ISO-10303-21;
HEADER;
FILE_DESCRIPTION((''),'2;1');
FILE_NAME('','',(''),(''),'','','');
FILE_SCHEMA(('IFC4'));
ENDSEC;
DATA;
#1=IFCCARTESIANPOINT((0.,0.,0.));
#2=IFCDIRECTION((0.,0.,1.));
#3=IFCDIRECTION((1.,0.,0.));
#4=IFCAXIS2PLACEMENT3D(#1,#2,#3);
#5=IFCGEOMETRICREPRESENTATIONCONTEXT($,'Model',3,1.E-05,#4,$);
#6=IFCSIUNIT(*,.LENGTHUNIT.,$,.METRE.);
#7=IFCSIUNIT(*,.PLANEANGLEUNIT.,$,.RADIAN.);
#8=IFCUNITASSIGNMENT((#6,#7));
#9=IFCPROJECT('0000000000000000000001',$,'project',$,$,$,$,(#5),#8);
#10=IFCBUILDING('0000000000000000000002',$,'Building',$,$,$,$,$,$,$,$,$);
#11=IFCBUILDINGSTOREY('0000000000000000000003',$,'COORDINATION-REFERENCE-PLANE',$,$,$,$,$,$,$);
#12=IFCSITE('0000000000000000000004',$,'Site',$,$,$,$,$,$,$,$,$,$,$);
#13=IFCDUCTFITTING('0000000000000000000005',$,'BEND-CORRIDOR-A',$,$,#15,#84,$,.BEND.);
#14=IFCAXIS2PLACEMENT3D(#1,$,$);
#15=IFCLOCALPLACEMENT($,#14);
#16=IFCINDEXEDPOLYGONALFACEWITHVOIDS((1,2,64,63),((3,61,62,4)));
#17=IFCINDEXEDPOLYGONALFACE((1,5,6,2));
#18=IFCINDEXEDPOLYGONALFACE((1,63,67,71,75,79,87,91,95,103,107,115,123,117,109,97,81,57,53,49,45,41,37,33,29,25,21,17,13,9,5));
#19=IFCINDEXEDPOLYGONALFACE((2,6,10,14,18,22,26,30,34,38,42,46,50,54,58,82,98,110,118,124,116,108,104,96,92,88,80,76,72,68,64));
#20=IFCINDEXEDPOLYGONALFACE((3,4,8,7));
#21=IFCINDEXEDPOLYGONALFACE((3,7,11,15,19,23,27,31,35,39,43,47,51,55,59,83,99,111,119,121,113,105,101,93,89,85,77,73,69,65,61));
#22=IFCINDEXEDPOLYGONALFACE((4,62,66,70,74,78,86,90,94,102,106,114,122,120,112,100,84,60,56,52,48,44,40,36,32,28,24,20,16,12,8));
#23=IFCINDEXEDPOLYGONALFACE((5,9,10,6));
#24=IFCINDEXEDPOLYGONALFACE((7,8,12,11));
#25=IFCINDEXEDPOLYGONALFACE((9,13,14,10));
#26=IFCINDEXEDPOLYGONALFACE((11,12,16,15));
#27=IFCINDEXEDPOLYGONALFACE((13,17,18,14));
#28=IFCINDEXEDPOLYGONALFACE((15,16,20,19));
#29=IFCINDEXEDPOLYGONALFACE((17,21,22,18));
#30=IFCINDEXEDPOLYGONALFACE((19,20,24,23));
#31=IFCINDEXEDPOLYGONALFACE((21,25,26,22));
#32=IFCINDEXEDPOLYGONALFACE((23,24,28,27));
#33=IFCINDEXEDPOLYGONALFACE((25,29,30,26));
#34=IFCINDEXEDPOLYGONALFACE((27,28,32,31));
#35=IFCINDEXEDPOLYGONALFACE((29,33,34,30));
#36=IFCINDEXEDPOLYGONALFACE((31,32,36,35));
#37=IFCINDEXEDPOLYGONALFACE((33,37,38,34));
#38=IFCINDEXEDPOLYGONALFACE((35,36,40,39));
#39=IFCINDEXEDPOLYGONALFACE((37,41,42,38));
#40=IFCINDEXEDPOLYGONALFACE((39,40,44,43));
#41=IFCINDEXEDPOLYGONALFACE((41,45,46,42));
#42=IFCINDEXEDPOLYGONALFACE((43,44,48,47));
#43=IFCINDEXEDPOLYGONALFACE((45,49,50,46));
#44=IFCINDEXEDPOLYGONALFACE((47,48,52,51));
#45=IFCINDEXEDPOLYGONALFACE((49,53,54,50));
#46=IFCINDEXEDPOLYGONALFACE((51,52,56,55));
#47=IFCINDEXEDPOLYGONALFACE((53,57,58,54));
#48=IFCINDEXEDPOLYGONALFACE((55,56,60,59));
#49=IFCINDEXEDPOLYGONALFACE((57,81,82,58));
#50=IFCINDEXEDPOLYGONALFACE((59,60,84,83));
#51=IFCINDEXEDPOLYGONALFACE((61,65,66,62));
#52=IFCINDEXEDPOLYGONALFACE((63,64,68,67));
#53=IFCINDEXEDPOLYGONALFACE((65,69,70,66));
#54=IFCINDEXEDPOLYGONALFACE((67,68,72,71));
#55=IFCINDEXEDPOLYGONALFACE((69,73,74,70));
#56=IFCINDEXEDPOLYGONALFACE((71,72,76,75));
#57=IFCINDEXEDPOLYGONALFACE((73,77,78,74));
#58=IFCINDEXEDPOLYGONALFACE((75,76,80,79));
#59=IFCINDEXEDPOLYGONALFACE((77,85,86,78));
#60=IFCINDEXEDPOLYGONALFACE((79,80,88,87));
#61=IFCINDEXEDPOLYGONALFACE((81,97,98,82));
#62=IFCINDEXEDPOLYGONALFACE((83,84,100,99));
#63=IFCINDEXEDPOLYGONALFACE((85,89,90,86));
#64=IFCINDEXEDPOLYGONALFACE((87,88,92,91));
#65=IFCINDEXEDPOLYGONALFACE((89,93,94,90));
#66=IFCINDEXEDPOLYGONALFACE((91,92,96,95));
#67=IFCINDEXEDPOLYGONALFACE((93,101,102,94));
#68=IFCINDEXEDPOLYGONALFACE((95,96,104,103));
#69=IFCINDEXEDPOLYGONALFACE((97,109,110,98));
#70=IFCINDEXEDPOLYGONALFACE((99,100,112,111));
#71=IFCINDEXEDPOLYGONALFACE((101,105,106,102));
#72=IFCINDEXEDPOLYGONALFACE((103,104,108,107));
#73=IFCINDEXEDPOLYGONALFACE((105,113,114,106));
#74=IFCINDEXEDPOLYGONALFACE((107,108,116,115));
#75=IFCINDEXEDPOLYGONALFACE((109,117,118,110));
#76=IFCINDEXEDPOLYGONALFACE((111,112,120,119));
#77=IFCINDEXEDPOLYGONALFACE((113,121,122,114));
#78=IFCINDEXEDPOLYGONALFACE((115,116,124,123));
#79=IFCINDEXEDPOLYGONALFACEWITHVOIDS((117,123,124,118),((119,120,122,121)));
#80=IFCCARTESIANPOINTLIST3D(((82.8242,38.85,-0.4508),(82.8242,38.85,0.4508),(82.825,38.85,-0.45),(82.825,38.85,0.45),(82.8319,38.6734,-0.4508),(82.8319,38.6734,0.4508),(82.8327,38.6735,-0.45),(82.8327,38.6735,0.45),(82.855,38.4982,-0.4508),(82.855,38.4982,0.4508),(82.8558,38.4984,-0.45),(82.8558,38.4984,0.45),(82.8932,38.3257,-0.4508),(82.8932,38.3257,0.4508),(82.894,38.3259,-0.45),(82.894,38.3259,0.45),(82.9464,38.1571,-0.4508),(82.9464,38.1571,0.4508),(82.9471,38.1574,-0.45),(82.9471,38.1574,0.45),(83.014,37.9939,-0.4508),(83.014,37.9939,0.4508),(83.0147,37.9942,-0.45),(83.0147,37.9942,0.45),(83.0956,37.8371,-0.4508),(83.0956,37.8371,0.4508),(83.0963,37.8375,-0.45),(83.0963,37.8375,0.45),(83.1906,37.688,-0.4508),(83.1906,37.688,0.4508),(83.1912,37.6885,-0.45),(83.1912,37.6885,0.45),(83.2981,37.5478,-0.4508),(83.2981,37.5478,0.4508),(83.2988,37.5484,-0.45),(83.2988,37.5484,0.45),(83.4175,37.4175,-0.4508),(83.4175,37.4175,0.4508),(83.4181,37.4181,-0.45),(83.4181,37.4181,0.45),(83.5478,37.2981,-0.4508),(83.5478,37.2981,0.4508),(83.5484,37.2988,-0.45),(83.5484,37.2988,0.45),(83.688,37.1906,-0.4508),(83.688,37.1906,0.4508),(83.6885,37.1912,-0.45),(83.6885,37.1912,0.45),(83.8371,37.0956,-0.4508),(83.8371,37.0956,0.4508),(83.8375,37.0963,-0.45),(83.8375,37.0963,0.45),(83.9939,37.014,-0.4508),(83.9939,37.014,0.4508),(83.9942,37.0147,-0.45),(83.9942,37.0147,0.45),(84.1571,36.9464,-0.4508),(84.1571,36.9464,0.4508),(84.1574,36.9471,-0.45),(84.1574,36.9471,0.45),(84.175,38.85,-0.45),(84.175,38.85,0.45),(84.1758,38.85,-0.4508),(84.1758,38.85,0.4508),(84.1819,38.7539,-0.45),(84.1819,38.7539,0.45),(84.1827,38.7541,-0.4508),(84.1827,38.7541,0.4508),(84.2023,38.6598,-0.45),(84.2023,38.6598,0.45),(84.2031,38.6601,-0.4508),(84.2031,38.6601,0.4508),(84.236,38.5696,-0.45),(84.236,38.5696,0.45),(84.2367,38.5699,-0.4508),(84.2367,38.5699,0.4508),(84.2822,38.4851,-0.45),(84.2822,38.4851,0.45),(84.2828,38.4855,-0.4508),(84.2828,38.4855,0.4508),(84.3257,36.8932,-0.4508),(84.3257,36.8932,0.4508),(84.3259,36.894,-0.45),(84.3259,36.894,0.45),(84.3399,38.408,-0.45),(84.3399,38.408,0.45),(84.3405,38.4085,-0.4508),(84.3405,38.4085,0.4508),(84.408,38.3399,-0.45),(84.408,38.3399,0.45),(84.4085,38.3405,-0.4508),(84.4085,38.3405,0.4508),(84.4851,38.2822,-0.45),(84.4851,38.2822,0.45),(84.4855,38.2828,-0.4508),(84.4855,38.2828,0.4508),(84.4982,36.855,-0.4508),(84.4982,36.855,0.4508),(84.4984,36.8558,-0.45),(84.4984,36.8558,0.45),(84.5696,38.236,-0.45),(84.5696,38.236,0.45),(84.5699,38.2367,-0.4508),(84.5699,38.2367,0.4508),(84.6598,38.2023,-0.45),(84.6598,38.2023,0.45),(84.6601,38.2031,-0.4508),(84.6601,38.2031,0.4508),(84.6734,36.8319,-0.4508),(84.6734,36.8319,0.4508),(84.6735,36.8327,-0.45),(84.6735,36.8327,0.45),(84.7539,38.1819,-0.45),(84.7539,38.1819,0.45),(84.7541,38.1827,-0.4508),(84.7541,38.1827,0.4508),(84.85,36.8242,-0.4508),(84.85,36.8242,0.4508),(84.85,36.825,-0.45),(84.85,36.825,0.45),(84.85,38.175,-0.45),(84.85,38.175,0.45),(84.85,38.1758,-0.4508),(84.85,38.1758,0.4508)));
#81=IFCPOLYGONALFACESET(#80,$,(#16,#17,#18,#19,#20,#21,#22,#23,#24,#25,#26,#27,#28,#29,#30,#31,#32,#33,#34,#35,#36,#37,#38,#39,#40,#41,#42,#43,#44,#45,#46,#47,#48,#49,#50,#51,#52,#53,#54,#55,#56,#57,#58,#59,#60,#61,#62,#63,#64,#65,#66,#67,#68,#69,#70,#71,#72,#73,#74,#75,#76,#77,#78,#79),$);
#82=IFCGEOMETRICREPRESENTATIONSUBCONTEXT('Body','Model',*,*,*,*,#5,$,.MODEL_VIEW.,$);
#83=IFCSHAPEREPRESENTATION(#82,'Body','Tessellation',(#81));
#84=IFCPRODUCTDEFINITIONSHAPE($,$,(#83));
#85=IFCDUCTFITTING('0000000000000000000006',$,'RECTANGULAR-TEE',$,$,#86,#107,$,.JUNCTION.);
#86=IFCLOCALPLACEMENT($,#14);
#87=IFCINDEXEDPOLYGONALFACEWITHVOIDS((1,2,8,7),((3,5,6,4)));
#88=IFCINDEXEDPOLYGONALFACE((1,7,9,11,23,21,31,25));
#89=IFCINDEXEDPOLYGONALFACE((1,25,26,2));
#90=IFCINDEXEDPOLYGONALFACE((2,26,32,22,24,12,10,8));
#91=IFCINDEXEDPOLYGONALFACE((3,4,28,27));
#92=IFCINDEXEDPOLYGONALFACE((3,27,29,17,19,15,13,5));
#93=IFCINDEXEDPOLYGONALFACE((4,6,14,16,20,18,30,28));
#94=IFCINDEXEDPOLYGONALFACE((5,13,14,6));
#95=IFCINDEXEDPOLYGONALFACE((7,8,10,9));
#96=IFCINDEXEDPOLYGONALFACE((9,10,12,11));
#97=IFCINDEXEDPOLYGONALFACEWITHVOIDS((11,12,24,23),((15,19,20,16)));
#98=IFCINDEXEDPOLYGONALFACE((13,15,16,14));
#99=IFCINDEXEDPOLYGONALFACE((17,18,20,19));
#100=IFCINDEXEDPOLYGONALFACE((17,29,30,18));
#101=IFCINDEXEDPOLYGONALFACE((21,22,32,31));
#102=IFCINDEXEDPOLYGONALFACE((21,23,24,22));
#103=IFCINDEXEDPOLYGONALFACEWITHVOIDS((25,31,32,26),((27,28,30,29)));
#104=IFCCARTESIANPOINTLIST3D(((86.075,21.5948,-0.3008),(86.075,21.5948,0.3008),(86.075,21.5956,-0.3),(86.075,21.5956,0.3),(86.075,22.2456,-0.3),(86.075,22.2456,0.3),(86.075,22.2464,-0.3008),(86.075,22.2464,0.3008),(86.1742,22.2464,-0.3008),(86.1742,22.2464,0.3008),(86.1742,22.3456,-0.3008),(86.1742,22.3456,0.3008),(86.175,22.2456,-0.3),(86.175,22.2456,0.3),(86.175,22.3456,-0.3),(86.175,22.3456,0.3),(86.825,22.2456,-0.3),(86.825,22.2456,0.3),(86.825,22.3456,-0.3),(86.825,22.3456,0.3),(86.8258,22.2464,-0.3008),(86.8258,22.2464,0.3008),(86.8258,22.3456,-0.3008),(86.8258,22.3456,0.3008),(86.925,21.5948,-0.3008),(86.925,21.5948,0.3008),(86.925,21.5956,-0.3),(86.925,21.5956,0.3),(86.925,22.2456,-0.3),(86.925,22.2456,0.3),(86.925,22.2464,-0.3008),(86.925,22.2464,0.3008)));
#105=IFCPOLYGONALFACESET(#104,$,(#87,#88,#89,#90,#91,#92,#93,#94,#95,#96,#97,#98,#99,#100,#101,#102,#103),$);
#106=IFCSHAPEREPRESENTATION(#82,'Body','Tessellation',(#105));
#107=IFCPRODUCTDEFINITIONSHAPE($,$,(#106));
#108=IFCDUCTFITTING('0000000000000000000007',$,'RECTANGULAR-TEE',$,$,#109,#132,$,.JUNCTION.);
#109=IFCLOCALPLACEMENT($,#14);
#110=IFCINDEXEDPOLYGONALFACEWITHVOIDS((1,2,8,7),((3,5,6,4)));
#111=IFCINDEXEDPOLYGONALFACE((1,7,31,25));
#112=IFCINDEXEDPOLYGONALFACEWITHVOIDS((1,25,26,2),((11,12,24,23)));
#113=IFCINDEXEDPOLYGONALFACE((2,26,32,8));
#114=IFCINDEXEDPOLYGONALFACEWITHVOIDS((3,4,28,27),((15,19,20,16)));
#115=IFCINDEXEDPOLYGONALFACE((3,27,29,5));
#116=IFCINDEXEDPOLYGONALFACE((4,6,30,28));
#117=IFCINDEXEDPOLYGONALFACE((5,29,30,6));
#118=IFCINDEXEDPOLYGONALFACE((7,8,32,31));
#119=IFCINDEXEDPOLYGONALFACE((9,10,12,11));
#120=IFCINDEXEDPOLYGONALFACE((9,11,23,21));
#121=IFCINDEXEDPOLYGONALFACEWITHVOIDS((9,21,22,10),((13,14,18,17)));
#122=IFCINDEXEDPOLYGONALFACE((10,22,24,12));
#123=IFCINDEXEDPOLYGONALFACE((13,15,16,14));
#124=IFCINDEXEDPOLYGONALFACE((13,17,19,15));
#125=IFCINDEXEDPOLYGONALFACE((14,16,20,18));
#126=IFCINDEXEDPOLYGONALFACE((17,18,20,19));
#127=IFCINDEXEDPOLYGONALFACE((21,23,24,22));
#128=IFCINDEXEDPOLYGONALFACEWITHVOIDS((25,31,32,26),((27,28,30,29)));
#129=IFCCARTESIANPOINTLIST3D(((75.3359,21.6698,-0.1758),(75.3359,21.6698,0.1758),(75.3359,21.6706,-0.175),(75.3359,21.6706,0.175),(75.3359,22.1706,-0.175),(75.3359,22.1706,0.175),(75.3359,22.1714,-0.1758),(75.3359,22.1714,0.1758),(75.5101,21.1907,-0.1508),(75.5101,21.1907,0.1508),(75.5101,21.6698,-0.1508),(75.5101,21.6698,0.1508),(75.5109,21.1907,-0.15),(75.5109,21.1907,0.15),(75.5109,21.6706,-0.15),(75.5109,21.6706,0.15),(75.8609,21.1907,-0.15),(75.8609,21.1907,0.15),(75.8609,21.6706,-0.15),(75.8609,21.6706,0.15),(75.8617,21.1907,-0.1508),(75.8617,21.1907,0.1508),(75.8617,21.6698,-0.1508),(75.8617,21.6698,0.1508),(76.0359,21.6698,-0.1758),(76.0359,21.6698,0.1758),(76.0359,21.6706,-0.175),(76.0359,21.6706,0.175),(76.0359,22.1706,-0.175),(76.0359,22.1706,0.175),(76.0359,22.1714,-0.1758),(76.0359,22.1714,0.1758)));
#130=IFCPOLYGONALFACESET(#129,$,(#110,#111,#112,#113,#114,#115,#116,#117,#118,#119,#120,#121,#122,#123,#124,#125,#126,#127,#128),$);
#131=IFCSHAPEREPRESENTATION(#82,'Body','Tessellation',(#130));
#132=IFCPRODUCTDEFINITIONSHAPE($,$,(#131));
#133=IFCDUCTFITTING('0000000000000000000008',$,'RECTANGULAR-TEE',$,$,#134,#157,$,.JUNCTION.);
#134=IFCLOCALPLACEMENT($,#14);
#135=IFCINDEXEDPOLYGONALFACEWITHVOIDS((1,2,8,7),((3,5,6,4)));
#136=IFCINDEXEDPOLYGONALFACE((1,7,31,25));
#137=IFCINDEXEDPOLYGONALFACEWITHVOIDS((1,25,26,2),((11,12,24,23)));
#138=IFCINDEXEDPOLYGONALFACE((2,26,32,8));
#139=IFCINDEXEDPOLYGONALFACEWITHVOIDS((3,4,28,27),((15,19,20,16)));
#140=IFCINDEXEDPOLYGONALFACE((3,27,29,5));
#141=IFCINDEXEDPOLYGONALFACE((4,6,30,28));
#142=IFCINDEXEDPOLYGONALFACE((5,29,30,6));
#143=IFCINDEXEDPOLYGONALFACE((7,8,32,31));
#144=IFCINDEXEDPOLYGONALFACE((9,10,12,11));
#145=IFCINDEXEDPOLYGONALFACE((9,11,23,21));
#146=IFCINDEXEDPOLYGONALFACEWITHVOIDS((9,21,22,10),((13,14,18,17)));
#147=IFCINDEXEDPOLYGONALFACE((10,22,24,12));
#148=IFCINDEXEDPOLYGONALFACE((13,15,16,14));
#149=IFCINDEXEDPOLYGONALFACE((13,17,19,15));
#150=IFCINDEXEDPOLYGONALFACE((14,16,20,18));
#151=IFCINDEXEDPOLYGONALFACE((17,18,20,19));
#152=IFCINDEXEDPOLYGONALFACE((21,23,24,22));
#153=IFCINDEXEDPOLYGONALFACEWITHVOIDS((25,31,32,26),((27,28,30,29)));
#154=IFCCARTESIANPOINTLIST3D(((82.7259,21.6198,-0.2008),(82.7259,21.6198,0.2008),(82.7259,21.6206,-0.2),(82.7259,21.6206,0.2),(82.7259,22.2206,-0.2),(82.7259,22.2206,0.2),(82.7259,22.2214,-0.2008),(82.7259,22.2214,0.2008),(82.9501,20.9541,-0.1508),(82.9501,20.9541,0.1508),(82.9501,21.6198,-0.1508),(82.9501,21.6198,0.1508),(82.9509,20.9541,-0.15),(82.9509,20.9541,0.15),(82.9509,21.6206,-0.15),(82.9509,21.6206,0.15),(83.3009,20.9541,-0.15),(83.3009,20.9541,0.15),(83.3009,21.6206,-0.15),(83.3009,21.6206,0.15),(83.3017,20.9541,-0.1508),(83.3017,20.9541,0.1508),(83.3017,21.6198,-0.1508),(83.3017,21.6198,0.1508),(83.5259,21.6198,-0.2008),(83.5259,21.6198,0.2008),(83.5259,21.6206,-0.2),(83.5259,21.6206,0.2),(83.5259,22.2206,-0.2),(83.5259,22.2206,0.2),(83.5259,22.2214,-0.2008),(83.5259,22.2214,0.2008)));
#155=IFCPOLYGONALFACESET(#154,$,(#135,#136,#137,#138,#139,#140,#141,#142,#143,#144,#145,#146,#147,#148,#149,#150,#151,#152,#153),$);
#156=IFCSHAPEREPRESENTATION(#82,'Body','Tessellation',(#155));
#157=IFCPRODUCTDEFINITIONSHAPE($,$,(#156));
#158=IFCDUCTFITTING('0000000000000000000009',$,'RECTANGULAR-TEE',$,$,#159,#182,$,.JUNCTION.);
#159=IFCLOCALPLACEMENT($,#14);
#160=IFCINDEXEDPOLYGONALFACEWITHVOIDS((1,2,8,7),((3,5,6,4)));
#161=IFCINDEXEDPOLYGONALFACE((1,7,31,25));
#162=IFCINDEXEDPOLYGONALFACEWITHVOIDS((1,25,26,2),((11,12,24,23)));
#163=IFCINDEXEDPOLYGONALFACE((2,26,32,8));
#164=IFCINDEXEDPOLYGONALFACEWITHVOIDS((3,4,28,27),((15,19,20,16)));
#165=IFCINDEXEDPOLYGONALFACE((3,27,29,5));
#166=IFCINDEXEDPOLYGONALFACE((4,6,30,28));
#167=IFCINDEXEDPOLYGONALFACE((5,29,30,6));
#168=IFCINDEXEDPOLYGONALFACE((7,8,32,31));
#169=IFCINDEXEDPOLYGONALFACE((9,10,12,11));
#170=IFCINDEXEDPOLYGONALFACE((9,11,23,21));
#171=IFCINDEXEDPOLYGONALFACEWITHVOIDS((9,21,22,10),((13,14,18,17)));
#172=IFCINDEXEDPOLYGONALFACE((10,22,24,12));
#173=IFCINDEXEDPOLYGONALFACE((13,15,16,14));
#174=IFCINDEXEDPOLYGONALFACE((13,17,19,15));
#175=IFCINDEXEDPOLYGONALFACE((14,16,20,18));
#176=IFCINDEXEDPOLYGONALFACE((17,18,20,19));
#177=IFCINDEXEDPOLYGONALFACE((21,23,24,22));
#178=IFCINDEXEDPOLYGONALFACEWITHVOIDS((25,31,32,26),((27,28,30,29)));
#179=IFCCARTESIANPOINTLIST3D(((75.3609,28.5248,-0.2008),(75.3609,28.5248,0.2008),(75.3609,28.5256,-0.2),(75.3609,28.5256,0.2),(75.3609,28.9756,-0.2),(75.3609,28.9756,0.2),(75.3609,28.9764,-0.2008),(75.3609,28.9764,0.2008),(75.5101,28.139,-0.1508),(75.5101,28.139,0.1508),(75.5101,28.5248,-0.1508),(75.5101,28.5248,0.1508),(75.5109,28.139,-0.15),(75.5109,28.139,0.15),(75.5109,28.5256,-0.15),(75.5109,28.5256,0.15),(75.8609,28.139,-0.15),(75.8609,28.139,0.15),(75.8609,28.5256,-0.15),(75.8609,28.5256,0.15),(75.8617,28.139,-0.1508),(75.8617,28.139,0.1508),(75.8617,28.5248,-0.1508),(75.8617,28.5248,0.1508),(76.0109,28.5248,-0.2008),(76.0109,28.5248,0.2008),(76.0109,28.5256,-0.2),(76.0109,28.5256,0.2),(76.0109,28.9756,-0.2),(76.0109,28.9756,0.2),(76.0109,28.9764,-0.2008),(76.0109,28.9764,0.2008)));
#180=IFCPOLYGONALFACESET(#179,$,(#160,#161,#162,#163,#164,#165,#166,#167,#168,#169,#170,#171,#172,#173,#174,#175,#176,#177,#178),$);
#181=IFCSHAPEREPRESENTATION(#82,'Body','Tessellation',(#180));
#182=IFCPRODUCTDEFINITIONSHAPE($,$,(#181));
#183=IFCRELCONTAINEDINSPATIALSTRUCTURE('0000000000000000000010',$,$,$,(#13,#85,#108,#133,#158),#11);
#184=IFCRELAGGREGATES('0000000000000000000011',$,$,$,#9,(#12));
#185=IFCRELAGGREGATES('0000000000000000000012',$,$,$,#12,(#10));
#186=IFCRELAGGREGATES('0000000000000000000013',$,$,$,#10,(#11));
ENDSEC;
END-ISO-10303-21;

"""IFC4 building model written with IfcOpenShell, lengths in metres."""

from ifc_helpers import new_model, entity, si_unit, frame, origin_with_axes, place, context, subcontext, project, spatial, rectangle, extrude, boolean, element, save


model = new_model("IFC4")

# Units and contexts
model_context = context("Model", 3, precision=1e-05, world=origin_with_axes())
body_context = subcontext(model_context, "Body", "Model", "MODEL_VIEW")
ifc_project = project(units=[si_unit("LENGTHUNIT", "METRE"), si_unit("PLANEANGLEUNIT", "RADIAN")], contexts=[model_context])

# Site, building, storey
site = spatial("IfcSite", under=ifc_project, Name="Site")
building = spatial("IfcBuilding", under=site, Name="Building")
storey = spatial("IfcBuildingStorey", under=building, Name="COORDINATION-REFERENCE-PLANE")

# Duct fittings
duct_fitting_1_placement = place(None, frame((84.85, 38.85, 0.0), z_axis=(0.0, 0.0, 1.0), x_axis=(-1.0, 0.0, 0.0)))
cartesian_point_1 = entity("IfcCartesianPoint", [0.0, 0.0, 0.0])
element("IfcDuctFitting", 1, at=duct_fitting_1_placement, inside=storey, Name="BEND-CORRIDOR-A", PredefinedType="BEND", context=body_context, shape_type="SweptSolid", body=[
    entity("IfcRevolvedAreaSolid", entity("IfcRectangleHollowProfileDef", "AREA", None, entity("IfcAxis2Placement2D", entity("IfcCartesianPoint", [1.35, 0.0])), 1.3516, 0.9016, 0.0008), entity("IfcAxis2Placement3D", cartesian_point_1, entity("IfcDirection", [0.0, -1.0, 0.0]), entity("IfcDirection", [1.0, 0.0, 0.0])), entity("IfcAxis1Placement", cartesian_point_1, entity("IfcDirection", [0.0, 1.0, 0.0])), 1.570796),
])
duct_fitting_2_placement = place(None, frame((86.5, 21.9206, 0.0), z_axis=(1.0, 0.0, 0.0), x_axis=(0.0, 1.0, 0.0)))
solid_1 = boolean("UNION", extrude(rectangle(XDim=0.65, YDim=0.6), frame((0.0, 0.0, -0.425), z_axis=(0.0, 0.0, 1.0), x_axis=(1.0, 0.0, 0.0)), (0.0, 0.0, 1.0), 0.85), extrude(rectangle(XDim=0.65, YDim=0.6), frame((0.0, 0.0, 0.0), z_axis=(1.0, 0.0, 0.0), x_axis=(0.0, 0.0, -1.0)), (0.0, 0.0, 1.0), 0.425))
element("IfcDuctFitting", 2, at=duct_fitting_2_placement, inside=storey, Name="RECTANGULAR-TEE", PredefinedType="JUNCTION", context=body_context, shape_type="CSG", body=[
    boolean("DIFFERENCE", boolean("UNION", extrude(rectangle(XDim=0.6516, YDim=0.6016), frame((0.0, 0.0, -0.425), z_axis=(0.0, 0.0, 1.0), x_axis=(1.0, 0.0, 0.0)), (0.0, 0.0, 1.0), 0.85), extrude(rectangle(XDim=0.6516, YDim=0.6016), frame((0.0, 0.0, 0.0), z_axis=(1.0, 0.0, 0.0), x_axis=(0.0, 0.0, -1.0)), (0.0, 0.0, 1.0), 0.425)), solid_1),
])
duct_fitting_3_placement = place(None, frame((75.6859, 21.9206, 0.0), z_axis=(-1.0, 0.0, 0.0), x_axis=(0.0, -1.0, 0.0)))
solid_2 = boolean("UNION", extrude(rectangle(XDim=0.5, YDim=0.35), frame((0.0, 0.0, -0.35), z_axis=(0.0, 0.0, 1.0), x_axis=(1.0, 0.0, 0.0)), (0.0, 0.0, 1.0), 0.7), extrude(rectangle(XDim=0.35, YDim=0.3), frame((0.0, 0.0, 0.0), z_axis=(1.0, 0.0, 0.0), x_axis=(0.0, 0.0, -1.0)), (0.0, 0.0, 1.0), 0.7299))
element("IfcDuctFitting", 3, at=duct_fitting_3_placement, inside=storey, Name="RECTANGULAR-TEE", PredefinedType="JUNCTION", context=body_context, shape_type="CSG", body=[
    boolean("DIFFERENCE", boolean("UNION", extrude(rectangle(XDim=0.5016, YDim=0.3516), frame((0.0, 0.0, -0.35), z_axis=(0.0, 0.0, 1.0), x_axis=(1.0, 0.0, 0.0)), (0.0, 0.0, 1.0), 0.7), extrude(rectangle(XDim=0.3516, YDim=0.3016), frame((0.0, 0.0, 0.0), z_axis=(1.0, 0.0, 0.0), x_axis=(0.0, 0.0, -1.0)), (0.0, 0.0, 1.0), 0.7299)), solid_2),
])
duct_fitting_4_placement = place(None, frame((83.1259, 21.9206, 0.0), z_axis=(-1.0, 0.0, 0.0), x_axis=(0.0, -1.0, 0.0)))
solid_3 = boolean("UNION", extrude(rectangle(XDim=0.6, YDim=0.4), frame((0.0, 0.0, -0.4), z_axis=(0.0, 0.0, 1.0), x_axis=(1.0, 0.0, 0.0)), (0.0, 0.0, 1.0), 0.8), extrude(rectangle(XDim=0.35, YDim=0.3), frame((0.0, 0.0, 0.0), z_axis=(1.0, 0.0, 0.0), x_axis=(0.0, 0.0, -1.0)), (0.0, 0.0, 1.0), 0.9665))
element("IfcDuctFitting", 4, at=duct_fitting_4_placement, inside=storey, Name="RECTANGULAR-TEE", PredefinedType="JUNCTION", context=body_context, shape_type="CSG", body=[
    boolean("DIFFERENCE", boolean("UNION", extrude(rectangle(XDim=0.6016, YDim=0.4016), frame((0.0, 0.0, -0.4), z_axis=(0.0, 0.0, 1.0), x_axis=(1.0, 0.0, 0.0)), (0.0, 0.0, 1.0), 0.8), extrude(rectangle(XDim=0.3516, YDim=0.3016), frame((0.0, 0.0, 0.0), z_axis=(1.0, 0.0, 0.0), x_axis=(0.0, 0.0, -1.0)), (0.0, 0.0, 1.0), 0.9665)), solid_3),
])
duct_fitting_5_placement = place(None, frame((75.6859, 28.7506, 0.0), z_axis=(-1.0, 0.0, 0.0), x_axis=(0.0, -1.0, 0.0)))
solid_4 = boolean("UNION", extrude(rectangle(XDim=0.45, YDim=0.4), frame((0.0, 0.0, -0.325), z_axis=(0.0, 0.0, 1.0), x_axis=(1.0, 0.0, 0.0)), (0.0, 0.0, 1.0), 0.65), extrude(rectangle(XDim=0.35, YDim=0.3), frame((0.0, 0.0, 0.0), z_axis=(1.0, 0.0, 0.0), x_axis=(0.0, 0.0, -1.0)), (0.0, 0.0, 1.0), 0.6116))
element("IfcDuctFitting", 5, at=duct_fitting_5_placement, inside=storey, Name="RECTANGULAR-TEE", PredefinedType="JUNCTION", context=body_context, shape_type="CSG", body=[
    boolean("DIFFERENCE", boolean("UNION", extrude(rectangle(XDim=0.4516, YDim=0.4016), frame((0.0, 0.0, -0.325), z_axis=(0.0, 0.0, 1.0), x_axis=(1.0, 0.0, 0.0)), (0.0, 0.0, 1.0), 0.65), extrude(rectangle(XDim=0.3516, YDim=0.3016), frame((0.0, 0.0, 0.0), z_axis=(1.0, 0.0, 0.0), x_axis=(0.0, 0.0, -1.0)), (0.0, 0.0, 1.0), 0.6116)), solid_4),
])

save(model, "model.ifc")
